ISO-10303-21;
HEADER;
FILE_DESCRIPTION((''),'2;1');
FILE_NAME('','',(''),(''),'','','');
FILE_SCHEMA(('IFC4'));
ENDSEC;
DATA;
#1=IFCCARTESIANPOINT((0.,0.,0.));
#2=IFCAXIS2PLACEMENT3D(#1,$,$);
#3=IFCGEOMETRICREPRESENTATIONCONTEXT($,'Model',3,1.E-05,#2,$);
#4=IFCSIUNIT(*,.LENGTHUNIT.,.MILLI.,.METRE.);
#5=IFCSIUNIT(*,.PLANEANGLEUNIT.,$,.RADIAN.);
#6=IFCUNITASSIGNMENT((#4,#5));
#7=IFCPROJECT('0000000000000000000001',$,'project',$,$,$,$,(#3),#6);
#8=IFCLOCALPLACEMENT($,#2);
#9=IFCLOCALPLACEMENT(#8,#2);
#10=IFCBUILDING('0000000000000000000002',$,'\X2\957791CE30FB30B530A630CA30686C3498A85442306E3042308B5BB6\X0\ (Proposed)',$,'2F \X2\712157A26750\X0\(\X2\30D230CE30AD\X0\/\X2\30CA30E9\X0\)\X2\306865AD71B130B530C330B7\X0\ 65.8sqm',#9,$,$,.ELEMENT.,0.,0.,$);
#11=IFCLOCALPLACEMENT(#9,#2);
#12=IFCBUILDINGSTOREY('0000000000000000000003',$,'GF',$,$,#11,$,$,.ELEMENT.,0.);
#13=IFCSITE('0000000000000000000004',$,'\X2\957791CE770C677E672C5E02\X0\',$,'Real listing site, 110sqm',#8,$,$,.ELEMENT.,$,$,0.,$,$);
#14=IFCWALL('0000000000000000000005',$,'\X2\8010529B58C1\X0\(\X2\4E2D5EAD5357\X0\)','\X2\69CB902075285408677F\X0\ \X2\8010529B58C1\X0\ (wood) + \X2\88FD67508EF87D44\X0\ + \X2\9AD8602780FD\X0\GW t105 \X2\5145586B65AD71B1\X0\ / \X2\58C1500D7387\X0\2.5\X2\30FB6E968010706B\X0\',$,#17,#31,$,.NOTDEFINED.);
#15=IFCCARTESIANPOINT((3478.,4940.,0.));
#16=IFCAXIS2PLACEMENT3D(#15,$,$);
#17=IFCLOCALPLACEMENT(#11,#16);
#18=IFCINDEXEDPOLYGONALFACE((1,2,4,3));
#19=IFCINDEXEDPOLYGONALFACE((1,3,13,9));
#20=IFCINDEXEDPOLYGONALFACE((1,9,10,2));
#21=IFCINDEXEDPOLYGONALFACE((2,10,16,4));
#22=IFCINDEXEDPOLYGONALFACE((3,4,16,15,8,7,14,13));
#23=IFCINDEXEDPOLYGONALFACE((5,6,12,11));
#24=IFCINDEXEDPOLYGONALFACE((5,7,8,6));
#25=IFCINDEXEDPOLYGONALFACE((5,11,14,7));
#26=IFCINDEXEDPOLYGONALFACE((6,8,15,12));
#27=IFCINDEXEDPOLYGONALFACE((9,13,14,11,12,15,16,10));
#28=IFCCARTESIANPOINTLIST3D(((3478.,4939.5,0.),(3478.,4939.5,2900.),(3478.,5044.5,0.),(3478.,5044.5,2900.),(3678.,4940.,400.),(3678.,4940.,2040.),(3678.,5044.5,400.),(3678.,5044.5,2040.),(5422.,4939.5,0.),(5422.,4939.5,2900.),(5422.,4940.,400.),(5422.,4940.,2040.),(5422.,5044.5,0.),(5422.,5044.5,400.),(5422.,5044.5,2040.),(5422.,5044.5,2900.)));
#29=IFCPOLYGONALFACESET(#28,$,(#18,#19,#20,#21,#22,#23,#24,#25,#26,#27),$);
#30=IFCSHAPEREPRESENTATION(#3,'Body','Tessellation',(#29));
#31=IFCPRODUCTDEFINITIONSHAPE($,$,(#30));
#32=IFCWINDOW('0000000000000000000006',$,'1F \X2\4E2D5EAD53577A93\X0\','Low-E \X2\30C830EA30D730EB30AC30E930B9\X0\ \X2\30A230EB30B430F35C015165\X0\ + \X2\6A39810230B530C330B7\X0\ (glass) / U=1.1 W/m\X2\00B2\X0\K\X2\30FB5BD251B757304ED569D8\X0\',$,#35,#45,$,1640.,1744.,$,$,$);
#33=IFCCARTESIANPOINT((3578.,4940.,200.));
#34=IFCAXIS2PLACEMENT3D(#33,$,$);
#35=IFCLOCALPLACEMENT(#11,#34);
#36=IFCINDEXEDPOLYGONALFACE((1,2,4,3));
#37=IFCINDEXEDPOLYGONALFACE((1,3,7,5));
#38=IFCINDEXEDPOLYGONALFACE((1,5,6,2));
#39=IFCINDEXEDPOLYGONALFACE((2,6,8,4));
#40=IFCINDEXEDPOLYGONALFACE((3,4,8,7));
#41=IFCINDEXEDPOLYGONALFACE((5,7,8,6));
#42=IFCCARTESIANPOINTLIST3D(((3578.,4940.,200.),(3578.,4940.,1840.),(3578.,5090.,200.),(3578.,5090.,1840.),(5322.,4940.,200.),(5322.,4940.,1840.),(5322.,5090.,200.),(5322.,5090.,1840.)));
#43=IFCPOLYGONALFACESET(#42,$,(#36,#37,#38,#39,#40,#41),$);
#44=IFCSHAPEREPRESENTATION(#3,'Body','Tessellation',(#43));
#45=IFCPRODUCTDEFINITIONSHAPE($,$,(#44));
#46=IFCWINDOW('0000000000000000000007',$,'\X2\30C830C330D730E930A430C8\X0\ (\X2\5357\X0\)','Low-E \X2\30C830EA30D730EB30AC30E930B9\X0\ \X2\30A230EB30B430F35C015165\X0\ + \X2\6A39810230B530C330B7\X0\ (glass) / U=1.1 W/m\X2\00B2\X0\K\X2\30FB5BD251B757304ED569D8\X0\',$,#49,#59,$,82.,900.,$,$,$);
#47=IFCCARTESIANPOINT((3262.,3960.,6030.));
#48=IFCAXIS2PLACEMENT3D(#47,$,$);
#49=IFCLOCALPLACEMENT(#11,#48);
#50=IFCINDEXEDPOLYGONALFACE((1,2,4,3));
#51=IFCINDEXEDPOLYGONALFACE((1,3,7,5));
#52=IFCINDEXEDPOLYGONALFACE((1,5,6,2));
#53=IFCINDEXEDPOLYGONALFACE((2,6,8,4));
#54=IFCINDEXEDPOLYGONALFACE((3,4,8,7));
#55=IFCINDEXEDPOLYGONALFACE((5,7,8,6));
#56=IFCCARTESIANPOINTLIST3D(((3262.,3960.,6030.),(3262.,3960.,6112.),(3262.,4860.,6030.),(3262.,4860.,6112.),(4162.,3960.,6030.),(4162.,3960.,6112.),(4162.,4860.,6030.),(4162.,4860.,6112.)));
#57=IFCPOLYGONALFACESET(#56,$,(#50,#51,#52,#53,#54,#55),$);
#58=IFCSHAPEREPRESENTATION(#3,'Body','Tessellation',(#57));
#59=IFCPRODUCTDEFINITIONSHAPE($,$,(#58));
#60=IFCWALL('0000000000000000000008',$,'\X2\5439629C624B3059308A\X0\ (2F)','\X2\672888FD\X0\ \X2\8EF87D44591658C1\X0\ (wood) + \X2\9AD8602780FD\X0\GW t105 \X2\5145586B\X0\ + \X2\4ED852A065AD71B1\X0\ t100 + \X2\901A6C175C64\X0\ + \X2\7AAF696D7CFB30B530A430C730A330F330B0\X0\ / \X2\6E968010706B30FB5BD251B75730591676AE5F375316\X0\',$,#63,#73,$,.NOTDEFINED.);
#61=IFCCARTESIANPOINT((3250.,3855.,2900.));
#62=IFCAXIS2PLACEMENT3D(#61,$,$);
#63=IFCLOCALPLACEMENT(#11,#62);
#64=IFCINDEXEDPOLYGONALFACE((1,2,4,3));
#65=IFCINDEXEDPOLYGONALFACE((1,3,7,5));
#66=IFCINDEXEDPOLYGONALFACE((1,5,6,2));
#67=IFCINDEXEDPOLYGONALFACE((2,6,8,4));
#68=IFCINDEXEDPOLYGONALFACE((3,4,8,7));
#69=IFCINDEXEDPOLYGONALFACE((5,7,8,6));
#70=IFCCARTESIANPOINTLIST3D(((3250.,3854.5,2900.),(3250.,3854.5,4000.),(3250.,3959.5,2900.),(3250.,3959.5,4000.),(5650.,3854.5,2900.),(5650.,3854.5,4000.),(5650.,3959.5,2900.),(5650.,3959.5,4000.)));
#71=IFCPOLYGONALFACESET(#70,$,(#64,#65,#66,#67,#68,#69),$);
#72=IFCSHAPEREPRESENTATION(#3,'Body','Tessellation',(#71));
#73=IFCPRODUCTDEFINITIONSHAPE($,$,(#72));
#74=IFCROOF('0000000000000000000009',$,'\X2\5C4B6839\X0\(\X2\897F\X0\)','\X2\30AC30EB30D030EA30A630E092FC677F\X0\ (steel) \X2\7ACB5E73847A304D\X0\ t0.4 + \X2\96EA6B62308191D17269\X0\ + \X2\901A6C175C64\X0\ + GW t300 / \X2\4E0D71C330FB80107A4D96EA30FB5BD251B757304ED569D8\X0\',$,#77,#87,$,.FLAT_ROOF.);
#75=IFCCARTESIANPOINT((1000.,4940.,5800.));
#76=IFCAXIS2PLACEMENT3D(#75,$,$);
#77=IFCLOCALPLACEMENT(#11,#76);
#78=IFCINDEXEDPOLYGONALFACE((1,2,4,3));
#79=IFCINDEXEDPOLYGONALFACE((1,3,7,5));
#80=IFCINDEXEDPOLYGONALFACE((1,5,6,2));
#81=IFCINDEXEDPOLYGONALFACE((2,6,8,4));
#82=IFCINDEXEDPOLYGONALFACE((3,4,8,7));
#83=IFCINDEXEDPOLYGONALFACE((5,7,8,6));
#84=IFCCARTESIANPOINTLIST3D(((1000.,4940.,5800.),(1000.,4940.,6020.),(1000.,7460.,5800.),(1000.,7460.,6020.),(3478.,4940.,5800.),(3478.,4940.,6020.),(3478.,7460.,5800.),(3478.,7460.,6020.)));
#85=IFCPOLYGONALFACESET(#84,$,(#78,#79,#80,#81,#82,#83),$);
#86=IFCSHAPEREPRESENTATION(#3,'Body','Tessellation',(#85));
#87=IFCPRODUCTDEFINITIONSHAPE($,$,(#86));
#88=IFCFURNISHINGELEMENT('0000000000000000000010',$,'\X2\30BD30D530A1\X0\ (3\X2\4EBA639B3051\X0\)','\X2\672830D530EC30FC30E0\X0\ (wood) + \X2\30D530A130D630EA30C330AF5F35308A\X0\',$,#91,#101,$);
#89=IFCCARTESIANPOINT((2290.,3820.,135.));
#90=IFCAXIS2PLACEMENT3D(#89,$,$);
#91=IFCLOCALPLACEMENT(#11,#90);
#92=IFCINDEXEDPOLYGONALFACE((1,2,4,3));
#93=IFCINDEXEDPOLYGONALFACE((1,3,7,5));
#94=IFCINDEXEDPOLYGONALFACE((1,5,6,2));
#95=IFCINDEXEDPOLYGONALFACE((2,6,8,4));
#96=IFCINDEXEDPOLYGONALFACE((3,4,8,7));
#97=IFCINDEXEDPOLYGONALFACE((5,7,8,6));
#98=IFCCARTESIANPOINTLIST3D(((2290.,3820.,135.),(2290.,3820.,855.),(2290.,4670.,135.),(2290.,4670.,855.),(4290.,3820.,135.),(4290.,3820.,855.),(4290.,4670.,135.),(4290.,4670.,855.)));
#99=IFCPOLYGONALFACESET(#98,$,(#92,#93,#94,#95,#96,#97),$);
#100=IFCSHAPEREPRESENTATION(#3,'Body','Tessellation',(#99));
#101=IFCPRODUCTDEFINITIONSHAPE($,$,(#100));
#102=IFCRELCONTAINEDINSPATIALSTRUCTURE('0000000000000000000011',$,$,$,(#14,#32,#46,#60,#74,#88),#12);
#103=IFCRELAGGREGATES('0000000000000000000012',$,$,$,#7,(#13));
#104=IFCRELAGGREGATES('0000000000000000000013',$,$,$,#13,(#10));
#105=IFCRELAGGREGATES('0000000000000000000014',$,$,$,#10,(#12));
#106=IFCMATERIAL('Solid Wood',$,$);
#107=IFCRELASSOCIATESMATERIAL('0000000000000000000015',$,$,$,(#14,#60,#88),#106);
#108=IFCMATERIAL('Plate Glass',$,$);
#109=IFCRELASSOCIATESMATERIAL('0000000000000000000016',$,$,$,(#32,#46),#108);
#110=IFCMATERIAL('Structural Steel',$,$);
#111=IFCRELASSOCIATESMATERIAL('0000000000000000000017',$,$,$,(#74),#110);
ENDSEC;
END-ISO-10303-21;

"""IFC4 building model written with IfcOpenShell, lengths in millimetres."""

from ifc_helpers import new_model, si_unit, frame, frame_2d, origin, place, context, project, spatial, rectangle, extrude, material, element, fill, save


model = new_model("IFC4")

# Units and contexts
model_context = context("Model", 3, precision=1e-05, world=origin())
ifc_project = project(units=[si_unit("LENGTHUNIT", "METRE", prefix="MILLI"), si_unit("PLANEANGLEUNIT", "RADIAN")], contexts=[model_context])

# Site, building, storey
site_placement = place(None, origin())
site = spatial("IfcSite", under=ifc_project, at=site_placement, Name="長野県松本市", ObjectType="Real listing site, 110sqm", CompositionType="ELEMENT", RefElevation=0.0)
building_placement = place(site_placement, origin())
building = spatial("IfcBuilding", under=site, at=building_placement, Name="長野・サウナと水風呂のある家 (Proposed)", ObjectType="2F 無垢材(ヒノキ/ナラ)と断熱サッシ 65.8sqm", CompositionType="ELEMENT", ElevationOfRefHeight=0.0, ElevationOfTerrain=0.0)
storey_placement = place(building_placement, origin())
storey = spatial("IfcBuildingStorey", under=building, at=storey_placement, Name="GF", CompositionType="ELEMENT", Elevation=0.0)

# Shared definitions
ifc_material_1 = material(Name="Solid Wood")

# Wall, opening, window
wall_1_placement = place(storey_placement, frame((3478.0, 4940.0, 0.0)))
wall_1 = element("IfcWall", 1, at=wall_1_placement, inside=storey, material=ifc_material_1, Name="耐力壁(中庭南)", Description="構造用合板 耐力壁 (wood) + 製材軸組 + 高性能GW t105 充填断熱 / 壁倍率2.5・準耐火", PredefinedType="NOTDEFINED", context=model_context, shape_type="SweptSolid", body=[
    extrude(rectangle(XDim=1944.0, YDim=105.0, at=frame_2d((972.0, 52.0))), frame((3478.0, 4940.0, 0.0)), (0.0, 0.0, 1.0), 2900.0),
])
opening_placement = place(storey_placement, frame((3578.0, 4940.0, 200.0)))
opening = element("IfcOpeningElement", 2, at=opening_placement, cuts=wall_1, PredefinedType="NOTDEFINED", context=model_context, shape_type="SweptSolid", body=[
    extrude(rectangle(XDim=1744.0, YDim=150.0, at=frame_2d((872.0, 75.0))), frame((3578.0, 4940.0, 200.0)), (0.0, 0.0, 1.0), 1640.0),
])
ifc_material_2 = material(Name="Plate Glass")
window_1_placement = place(storey_placement, frame((3578.0, 4940.0, 200.0)))
window_1 = element("IfcWindow", 3, at=window_1_placement, inside=storey, material=ifc_material_2, Name="1F 中庭南窓", Description="Low-E トリプルガラス アルゴン封入 + 樹脂サッシ (glass) / U=1.1 W/m²K・寒冷地仕様", OverallHeight=1640.0, OverallWidth=1744.0, context=model_context, shape_type="SweptSolid", body=[
    extrude(rectangle(XDim=1744.0, YDim=150.0, at=frame_2d((872.0, 75.0))), frame((3578.0, 4940.0, 200.0)), (0.0, 0.0, 1.0), 1640.0),
])
fill(opening, window_1)

# Window
window_2_placement = place(storey_placement, frame((3262.0, 3960.0, 6030.0)))
element("IfcWindow", 4, at=window_2_placement, inside=storey, material=ifc_material_2, Name="トップライト (南)", Description="Low-E トリプルガラス アルゴン封入 + 樹脂サッシ (glass) / U=1.1 W/m²K・寒冷地仕様", OverallHeight=82.0, OverallWidth=900.0, context=model_context, shape_type="SweptSolid", body=[
    extrude(rectangle(XDim=900.0, YDim=900.0, at=frame_2d((450.0, 450.0))), frame((3262.0, 3960.0, 6030.0)), (0.0, 0.0, 1.0), 82.0),
])

# Wall
wall_2_placement = place(storey_placement, frame((3250.0, 3855.0, 2900.0)))
element("IfcWall", 5, at=wall_2_placement, inside=storey, material=ifc_material_1, Name="吹抜手すり (2F)", Description="木製 軸組外壁 (wood) + 高性能GW t105 充填 + 付加断熱 t100 + 通気層 + 窯業系サイディング / 準耐火・寒冷地外皮強化", PredefinedType="NOTDEFINED", context=model_context, shape_type="SweptSolid", body=[
    extrude(rectangle(XDim=2400.0, YDim=105.0, at=frame_2d((1200.0, 52.0))), frame((3250.0, 3855.0, 2900.0)), (0.0, 0.0, 1.0), 1100.0),
])

# Roof
ifc_material_3 = material(Name="Structural Steel")
for number, where, name in (
    (6, (1000.0, 4940.0, 5800.0), "屋根(西)"),
):
    element("IfcRoof", number, at=place(storey_placement, frame(where)), inside=storey, material=ifc_material_3, Name=name, Description="ガルバリウム鋼板 (steel) 立平葺き t0.4 + 雪止め金物 + 通気層 + GW t300 / 不燃・耐積雪・寒冷地仕様", PredefinedType="FLAT_ROOF", context=model_context, shape_type="SweptSolid", body=[
        extrude(rectangle(XDim=2478.0, YDim=2520.0, at=frame_2d((1239.0, 1260.0))), frame((1000.0, 4940.0, 5800.0)), (0.0, 0.0, 1.0), 220.0),
    ])

# Furnishing element
furnishing_placement = place(storey_placement, frame((2290.0, 3820.0, 135.0)))
element("IfcFurnishingElement", 7, at=furnishing_placement, inside=storey, material=ifc_material_1, Name="ソファ (3人掛け)", Description="木フレーム (wood) + ファブリック張り", context=model_context, shape_type="SweptSolid", body=[
    extrude(rectangle(XDim=2000.0, YDim=850.0, at=frame_2d((1000.0, 425.0))), frame((2290.0, 3820.0, 135.0)), (0.0, 0.0, 1.0), 720.0),
])

save(model, "model.ifc")
